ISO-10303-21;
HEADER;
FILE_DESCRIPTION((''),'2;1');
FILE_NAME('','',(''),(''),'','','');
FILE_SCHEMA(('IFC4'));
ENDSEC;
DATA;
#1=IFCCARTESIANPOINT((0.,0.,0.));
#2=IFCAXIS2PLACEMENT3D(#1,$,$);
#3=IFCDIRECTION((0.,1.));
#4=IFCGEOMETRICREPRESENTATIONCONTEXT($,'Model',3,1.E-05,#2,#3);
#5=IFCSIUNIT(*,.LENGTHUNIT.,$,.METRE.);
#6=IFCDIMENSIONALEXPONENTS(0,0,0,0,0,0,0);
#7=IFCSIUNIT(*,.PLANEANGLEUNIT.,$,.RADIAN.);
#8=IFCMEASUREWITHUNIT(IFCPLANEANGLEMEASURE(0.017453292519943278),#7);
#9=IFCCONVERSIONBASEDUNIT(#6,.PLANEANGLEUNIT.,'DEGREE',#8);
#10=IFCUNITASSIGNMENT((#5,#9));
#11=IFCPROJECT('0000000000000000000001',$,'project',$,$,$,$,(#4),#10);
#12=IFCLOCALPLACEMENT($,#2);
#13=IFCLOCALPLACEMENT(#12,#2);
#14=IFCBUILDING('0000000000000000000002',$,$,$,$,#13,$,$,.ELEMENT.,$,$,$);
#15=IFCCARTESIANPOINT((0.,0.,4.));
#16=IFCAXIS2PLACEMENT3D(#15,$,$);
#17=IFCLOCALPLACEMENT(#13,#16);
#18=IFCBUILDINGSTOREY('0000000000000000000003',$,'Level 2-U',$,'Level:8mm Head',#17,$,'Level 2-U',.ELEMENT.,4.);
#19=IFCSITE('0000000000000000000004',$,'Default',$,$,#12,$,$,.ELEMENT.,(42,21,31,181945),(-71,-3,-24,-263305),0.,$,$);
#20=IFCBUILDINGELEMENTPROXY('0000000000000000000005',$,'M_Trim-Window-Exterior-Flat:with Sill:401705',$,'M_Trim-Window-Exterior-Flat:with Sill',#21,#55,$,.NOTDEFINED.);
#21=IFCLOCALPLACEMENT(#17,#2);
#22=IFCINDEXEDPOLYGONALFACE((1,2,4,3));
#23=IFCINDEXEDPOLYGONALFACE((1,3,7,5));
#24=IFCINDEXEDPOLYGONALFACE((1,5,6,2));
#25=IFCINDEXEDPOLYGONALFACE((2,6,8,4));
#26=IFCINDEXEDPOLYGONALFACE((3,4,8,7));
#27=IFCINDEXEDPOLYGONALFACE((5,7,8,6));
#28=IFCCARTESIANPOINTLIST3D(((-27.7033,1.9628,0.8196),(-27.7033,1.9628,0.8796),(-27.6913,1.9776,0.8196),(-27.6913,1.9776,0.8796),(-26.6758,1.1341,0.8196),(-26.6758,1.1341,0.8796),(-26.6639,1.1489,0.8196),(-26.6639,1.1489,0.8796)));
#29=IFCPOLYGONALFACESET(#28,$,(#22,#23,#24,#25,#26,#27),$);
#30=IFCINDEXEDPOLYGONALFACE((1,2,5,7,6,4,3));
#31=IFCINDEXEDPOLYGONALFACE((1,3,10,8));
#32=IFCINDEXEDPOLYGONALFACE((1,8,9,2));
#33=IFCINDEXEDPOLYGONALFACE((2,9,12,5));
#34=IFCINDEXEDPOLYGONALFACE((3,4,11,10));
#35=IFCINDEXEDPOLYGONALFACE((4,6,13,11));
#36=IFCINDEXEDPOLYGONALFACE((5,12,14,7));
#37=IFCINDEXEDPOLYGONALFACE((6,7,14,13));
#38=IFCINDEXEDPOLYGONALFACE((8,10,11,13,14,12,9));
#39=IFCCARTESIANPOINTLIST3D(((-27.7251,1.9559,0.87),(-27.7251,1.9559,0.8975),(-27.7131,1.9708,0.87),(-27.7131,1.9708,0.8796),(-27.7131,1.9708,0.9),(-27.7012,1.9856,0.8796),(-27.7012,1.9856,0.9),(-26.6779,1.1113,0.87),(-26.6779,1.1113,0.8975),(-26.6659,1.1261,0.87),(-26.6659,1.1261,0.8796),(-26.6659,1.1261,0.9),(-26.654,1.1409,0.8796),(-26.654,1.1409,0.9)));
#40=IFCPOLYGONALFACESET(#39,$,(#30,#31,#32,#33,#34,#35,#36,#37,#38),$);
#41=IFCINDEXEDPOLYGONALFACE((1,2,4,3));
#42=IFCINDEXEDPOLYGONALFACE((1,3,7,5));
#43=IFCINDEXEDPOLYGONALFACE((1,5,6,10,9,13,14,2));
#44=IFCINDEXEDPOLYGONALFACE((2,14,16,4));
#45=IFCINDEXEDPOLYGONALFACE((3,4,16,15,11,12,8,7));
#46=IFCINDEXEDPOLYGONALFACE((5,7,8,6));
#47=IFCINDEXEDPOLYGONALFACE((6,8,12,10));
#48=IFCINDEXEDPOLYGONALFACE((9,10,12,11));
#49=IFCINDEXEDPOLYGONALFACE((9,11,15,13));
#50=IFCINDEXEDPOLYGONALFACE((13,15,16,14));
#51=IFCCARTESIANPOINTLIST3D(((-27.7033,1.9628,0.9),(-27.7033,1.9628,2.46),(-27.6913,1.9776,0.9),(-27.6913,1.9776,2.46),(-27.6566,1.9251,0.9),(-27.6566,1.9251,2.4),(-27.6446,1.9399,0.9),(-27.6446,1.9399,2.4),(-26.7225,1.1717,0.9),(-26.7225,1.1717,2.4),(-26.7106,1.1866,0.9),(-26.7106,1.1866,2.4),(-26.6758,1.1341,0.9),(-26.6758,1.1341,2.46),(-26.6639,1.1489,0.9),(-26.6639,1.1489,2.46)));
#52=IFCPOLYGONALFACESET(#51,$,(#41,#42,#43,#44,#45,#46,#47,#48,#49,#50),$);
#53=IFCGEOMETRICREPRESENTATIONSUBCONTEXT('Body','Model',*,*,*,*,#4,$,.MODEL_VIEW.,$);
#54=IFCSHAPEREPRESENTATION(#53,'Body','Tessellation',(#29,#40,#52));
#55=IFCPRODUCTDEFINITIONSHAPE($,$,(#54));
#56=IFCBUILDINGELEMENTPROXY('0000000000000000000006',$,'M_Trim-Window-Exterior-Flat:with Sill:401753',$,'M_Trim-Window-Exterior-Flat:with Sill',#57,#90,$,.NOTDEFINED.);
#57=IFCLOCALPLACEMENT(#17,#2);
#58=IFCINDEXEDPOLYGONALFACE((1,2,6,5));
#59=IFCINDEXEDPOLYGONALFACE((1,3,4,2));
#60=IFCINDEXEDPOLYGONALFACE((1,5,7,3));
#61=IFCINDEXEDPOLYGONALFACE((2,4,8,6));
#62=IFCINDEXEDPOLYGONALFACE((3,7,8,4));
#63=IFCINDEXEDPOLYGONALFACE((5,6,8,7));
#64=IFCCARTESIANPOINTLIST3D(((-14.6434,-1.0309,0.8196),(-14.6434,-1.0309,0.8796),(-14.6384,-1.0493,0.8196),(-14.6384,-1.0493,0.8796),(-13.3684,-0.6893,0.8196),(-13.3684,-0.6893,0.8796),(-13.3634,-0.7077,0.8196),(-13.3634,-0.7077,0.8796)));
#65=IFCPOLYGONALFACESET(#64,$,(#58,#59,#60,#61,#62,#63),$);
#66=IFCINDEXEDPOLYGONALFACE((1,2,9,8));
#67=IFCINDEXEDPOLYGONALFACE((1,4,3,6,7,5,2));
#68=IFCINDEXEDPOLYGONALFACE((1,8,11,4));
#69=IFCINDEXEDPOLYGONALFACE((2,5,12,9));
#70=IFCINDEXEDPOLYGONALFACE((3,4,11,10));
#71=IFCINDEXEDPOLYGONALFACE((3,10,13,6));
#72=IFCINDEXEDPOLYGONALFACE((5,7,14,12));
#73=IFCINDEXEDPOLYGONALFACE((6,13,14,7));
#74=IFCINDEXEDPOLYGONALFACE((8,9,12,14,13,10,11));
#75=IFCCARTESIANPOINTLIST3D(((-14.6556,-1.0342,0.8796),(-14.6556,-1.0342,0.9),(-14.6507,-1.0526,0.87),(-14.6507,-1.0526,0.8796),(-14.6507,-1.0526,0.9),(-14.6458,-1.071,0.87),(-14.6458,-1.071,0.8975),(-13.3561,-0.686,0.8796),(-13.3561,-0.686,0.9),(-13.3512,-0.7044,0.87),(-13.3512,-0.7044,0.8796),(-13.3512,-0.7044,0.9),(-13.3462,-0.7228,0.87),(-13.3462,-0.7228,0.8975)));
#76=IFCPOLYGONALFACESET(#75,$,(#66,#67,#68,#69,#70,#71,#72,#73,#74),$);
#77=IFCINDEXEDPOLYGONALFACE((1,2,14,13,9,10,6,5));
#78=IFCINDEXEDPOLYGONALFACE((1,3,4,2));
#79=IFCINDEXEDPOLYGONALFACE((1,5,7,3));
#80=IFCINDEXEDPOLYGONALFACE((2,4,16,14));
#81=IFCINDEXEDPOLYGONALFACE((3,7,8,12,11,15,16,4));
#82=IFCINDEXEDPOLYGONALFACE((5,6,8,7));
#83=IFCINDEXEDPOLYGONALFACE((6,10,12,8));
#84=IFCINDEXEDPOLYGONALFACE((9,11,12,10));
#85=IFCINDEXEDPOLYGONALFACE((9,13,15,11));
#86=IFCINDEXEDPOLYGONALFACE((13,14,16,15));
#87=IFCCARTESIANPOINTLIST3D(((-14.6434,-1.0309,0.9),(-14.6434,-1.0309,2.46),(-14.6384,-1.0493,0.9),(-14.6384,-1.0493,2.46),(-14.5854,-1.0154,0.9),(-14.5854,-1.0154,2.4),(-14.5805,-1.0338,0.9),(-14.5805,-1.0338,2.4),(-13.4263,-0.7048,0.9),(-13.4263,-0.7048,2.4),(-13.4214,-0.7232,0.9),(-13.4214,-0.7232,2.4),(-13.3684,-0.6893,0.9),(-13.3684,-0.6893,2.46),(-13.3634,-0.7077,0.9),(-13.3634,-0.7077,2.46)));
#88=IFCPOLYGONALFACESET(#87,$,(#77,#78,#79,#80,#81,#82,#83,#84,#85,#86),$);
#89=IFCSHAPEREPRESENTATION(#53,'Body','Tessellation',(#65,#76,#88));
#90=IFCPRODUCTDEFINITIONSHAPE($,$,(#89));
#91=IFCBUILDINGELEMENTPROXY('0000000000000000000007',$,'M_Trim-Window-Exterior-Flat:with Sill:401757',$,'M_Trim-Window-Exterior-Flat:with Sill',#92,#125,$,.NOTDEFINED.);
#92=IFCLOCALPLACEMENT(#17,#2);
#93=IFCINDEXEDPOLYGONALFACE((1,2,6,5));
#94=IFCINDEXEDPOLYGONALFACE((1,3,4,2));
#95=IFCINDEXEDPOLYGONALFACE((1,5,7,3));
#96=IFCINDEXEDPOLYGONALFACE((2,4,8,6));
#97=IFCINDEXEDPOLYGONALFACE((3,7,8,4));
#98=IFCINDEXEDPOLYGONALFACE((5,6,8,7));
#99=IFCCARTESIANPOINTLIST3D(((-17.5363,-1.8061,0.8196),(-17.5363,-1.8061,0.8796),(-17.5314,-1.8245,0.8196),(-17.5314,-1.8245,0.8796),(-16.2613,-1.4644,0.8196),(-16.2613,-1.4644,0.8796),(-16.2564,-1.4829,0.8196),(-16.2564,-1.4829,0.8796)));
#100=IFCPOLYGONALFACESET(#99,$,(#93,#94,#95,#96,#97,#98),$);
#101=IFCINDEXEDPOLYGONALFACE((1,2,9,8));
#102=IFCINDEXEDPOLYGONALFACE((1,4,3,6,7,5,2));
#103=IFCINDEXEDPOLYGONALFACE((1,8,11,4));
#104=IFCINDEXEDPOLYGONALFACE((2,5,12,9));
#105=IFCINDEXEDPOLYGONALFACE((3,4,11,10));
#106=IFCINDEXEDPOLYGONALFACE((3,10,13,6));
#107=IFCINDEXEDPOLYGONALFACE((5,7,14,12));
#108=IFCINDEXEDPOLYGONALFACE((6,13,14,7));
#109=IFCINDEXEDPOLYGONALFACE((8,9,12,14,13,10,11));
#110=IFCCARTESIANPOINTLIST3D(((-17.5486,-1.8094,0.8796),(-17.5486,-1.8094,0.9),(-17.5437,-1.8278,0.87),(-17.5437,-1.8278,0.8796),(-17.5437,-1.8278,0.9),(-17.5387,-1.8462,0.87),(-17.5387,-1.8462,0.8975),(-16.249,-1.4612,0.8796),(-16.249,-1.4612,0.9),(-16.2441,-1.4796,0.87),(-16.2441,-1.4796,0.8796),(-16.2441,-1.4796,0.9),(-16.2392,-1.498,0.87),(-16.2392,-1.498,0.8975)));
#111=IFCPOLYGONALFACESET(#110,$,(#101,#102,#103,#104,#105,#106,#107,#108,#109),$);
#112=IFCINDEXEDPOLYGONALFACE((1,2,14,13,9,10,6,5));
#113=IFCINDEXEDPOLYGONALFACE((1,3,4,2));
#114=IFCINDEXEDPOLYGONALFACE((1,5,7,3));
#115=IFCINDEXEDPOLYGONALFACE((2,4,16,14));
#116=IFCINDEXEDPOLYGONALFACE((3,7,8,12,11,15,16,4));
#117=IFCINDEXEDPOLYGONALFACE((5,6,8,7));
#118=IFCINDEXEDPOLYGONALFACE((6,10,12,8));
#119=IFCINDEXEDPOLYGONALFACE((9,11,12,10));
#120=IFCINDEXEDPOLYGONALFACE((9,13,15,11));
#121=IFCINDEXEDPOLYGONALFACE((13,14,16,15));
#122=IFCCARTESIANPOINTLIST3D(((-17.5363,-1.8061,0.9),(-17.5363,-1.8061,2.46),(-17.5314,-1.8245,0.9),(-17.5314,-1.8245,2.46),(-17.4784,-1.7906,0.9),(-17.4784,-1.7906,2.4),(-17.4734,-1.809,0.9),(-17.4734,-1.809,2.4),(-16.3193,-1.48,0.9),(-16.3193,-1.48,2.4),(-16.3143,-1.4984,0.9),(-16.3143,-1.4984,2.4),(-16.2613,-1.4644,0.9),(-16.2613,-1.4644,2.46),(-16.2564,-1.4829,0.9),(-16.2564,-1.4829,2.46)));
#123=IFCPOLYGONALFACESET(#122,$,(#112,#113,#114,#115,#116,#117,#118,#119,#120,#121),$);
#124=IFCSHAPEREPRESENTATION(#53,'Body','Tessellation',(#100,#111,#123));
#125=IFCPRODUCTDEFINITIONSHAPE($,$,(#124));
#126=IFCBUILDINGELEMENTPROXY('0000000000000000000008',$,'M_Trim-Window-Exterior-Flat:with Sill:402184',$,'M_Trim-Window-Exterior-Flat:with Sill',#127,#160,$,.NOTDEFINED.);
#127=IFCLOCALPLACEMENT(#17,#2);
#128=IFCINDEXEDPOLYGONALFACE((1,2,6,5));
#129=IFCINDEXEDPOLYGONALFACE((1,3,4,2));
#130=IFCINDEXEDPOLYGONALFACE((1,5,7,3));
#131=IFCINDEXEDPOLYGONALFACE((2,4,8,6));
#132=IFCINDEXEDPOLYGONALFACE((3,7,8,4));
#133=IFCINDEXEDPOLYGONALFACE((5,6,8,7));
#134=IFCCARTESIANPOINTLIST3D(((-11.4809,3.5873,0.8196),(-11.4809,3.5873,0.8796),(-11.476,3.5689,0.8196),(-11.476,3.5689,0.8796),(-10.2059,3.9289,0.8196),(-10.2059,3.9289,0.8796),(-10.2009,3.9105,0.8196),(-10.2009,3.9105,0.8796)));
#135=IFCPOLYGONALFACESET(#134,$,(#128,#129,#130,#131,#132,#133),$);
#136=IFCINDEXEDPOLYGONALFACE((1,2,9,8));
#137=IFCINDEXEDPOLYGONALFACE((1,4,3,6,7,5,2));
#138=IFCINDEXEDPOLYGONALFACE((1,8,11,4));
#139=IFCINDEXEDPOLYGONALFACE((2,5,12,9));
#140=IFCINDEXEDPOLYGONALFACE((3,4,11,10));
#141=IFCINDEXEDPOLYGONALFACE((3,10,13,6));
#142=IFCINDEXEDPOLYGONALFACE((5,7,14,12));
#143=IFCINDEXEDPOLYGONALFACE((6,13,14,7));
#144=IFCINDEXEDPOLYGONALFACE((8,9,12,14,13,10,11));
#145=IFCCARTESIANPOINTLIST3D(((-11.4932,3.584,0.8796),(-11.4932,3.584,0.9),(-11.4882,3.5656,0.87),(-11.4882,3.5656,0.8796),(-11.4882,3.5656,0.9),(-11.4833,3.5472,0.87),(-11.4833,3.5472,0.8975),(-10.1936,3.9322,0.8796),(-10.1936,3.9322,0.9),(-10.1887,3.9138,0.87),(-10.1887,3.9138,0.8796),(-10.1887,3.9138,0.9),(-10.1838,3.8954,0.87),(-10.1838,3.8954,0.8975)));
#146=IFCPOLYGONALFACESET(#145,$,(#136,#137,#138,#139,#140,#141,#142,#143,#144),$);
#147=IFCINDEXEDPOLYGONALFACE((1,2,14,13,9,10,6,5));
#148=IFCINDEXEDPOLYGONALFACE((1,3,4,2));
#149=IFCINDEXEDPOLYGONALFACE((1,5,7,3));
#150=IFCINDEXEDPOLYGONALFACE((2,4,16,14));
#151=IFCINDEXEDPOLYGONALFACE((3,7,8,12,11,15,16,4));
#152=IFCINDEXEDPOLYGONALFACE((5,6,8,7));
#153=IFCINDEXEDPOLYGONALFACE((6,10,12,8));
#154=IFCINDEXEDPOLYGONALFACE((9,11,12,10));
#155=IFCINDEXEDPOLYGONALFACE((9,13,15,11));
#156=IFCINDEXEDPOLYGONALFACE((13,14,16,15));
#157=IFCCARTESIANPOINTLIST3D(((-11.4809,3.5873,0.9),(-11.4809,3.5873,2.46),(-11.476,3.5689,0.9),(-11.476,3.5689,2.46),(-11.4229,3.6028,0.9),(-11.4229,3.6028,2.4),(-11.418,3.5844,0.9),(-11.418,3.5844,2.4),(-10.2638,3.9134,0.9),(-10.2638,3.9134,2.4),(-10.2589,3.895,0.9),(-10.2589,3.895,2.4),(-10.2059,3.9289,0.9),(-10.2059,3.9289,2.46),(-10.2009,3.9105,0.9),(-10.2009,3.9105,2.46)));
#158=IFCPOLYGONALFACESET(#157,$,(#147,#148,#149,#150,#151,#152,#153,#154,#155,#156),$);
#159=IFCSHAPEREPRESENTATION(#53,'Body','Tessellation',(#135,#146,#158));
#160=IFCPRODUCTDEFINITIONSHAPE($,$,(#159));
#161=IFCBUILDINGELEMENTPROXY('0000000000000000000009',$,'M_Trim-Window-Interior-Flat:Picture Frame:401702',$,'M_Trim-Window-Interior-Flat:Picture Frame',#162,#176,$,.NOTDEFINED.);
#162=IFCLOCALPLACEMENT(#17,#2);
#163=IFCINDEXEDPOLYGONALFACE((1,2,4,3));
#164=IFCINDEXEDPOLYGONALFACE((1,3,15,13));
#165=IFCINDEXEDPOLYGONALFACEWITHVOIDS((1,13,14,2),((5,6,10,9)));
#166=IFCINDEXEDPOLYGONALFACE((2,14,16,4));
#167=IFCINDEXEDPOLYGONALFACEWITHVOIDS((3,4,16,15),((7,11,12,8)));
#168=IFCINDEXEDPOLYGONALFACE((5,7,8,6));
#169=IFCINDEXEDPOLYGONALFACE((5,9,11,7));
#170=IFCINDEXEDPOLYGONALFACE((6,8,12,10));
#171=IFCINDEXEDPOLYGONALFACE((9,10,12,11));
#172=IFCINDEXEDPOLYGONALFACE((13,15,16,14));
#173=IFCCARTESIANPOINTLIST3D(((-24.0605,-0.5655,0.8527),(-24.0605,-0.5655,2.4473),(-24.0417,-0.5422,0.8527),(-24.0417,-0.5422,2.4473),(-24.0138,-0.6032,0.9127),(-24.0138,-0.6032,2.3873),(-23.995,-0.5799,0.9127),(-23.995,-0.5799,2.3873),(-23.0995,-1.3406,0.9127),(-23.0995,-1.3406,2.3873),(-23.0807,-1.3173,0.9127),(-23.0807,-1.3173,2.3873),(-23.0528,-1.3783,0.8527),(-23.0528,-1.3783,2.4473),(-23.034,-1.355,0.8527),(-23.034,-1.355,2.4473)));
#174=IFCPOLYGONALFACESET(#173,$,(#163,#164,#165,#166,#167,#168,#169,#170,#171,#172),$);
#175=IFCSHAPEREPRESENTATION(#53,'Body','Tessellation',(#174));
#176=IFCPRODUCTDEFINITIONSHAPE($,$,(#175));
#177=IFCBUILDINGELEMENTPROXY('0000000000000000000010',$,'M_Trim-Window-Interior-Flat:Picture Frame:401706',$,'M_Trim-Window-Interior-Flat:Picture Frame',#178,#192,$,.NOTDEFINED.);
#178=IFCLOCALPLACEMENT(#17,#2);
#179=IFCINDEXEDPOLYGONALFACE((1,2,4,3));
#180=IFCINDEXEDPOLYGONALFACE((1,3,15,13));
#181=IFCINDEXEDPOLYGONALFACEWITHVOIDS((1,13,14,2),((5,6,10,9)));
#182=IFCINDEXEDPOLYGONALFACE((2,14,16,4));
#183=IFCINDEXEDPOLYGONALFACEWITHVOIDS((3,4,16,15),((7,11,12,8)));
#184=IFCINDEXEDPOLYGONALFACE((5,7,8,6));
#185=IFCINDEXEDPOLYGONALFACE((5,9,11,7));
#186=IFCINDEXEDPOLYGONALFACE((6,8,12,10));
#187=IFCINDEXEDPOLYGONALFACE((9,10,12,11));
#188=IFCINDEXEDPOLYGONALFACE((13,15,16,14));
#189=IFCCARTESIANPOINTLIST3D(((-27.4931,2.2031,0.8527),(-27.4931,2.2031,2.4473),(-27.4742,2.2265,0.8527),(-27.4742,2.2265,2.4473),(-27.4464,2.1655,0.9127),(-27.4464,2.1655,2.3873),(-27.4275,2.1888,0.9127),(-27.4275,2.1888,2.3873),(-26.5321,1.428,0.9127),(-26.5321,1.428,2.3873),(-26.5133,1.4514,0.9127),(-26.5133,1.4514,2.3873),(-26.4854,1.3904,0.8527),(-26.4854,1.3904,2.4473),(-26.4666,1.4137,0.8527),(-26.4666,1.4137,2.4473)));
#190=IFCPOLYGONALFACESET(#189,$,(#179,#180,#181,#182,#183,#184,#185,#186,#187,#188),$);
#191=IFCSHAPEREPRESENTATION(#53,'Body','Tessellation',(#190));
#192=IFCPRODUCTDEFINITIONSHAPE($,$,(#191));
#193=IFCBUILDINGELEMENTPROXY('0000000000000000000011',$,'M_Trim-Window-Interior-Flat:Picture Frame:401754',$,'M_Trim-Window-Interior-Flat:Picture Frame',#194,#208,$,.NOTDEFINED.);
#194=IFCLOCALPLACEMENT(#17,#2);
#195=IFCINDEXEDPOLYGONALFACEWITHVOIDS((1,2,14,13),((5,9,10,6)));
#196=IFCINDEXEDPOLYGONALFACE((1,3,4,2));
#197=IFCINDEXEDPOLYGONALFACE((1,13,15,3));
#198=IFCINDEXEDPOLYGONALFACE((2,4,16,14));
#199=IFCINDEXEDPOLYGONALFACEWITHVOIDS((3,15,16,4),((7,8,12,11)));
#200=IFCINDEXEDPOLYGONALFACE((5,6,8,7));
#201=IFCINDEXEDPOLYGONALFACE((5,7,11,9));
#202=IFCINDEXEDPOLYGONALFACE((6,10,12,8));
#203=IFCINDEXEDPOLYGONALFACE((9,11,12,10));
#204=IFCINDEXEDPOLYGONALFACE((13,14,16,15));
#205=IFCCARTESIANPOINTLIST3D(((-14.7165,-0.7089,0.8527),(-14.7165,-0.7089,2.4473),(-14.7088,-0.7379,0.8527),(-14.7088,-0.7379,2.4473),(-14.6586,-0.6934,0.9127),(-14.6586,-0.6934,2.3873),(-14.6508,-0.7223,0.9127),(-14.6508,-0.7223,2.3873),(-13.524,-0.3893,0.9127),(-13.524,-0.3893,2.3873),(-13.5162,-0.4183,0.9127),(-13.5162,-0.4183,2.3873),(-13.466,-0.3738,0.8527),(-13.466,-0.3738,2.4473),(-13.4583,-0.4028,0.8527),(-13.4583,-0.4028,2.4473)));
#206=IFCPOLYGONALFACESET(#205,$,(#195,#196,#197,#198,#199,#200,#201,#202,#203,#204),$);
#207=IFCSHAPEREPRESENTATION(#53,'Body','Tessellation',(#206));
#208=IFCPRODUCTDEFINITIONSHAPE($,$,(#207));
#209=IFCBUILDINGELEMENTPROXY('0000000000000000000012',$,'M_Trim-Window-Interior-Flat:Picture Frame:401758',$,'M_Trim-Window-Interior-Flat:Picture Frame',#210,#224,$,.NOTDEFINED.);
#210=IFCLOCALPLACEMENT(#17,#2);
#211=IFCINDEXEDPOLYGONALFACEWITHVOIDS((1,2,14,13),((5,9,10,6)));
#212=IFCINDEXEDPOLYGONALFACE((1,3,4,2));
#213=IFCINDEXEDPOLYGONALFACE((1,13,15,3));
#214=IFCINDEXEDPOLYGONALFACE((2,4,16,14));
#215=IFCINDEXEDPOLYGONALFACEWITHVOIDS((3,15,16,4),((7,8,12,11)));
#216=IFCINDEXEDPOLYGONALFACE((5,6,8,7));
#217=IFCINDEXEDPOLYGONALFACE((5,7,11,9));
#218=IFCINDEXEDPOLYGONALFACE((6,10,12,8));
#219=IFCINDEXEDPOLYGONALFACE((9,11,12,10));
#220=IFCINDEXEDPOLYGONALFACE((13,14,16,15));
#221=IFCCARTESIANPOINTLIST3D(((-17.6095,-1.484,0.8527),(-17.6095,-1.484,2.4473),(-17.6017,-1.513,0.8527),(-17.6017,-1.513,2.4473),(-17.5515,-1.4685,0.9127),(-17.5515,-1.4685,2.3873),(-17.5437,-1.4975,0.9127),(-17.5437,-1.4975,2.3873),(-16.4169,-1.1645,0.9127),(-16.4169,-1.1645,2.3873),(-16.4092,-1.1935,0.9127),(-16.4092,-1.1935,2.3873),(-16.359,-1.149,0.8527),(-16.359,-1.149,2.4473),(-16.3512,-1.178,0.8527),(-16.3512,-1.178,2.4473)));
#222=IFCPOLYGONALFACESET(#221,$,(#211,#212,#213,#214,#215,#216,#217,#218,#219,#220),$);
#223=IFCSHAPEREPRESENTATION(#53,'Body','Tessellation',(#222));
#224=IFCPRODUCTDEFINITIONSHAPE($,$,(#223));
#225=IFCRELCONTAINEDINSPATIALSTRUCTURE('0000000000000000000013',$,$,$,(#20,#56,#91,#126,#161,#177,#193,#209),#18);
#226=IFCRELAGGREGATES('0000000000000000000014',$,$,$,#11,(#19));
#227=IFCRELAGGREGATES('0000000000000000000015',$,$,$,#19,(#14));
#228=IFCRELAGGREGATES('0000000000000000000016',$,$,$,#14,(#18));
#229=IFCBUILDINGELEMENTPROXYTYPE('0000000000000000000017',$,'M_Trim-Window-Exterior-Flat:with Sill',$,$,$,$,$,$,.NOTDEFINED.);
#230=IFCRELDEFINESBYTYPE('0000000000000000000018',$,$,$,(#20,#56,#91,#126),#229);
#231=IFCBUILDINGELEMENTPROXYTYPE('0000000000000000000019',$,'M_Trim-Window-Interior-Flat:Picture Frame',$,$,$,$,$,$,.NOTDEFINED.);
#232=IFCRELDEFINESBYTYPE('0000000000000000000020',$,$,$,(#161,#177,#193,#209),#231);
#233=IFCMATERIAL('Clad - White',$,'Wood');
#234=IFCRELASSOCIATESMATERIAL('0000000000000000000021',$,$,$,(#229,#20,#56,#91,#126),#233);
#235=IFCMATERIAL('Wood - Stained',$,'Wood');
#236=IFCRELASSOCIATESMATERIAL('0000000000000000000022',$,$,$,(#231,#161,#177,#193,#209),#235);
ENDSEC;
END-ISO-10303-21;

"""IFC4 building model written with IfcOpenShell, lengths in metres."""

from ifc_helpers import new_model, entity, si_unit, converted_unit, direction, frame, frame_2d, origin, place, context, subcontext, project, spatial, polyline, rectangle, outline, extrude, source, transform, mapped, material, type_object, type_shapes, element, save


model = new_model("IFC4")

# Units and contexts
model_context = context("Model", 3, precision=1e-05, world=origin(), true_north=direction((0.0, 1.0)))
body_context = subcontext(model_context, "Body", "Model", "MODEL_VIEW")
ifc_project = project(units=[si_unit("LENGTHUNIT", "METRE"), converted_unit("PLANEANGLEUNIT", "DEGREE", entity("IfcPlaneAngleMeasure", 0.017453292519943278), si_unit("PLANEANGLEUNIT", "RADIAN"), dimensions=[0, 0, 0, 0, 0, 0, 0])], contexts=[model_context])

# Site, building, storey
site_placement = place(None, origin())
site = spatial("IfcSite", under=ifc_project, at=site_placement, Name="Default", CompositionType="ELEMENT", RefLatitude=(42, 21, 31, 181945), RefLongitude=(-71, -3, -24, -263305), RefElevation=0.0)
building_placement = place(site_placement, origin())
building = spatial("IfcBuilding", under=site, at=building_placement, CompositionType="ELEMENT")
storey_placement = place(building_placement, frame((0.0, 0.0, 4.0)))
storey = spatial("IfcBuildingStorey", under=building, at=storey_placement, Name="Level 2-U", ObjectType="Level:8mm Head", LongName="Level 2-U", CompositionType="ELEMENT", Elevation=4.0)

# Building element proxies
ifc_material_1 = material(Name="Clad - White", Category="Wood")
ifc_material_2 = material(Name="Wood - Stained", Category="Wood")
building_element_proxy_type_1 = type_object("IfcBuildingElementProxyType", Name="M_Trim-Window-Exterior-Flat:with Sill", PredefinedType="NOTDEFINED", material=ifc_material_1)
shared_shape_1 = source(origin(), body_context, "Body", "SweptSolid", [
    extrude(rectangle(XDim=1.32, YDim=0.06, at=frame_2d((0.0, 0.0), x_axis=(1.0, 0.0))), frame((0.0, -1.5504, 0.0), z_axis=(0.0, 0.0, 1.0), x_axis=(-1.0, 0.0, 0.0)), (0.0, 0.0, 1.0), 0.019),
    extrude(outline(polyline([(-0.019, -0.0152), (0.0, -0.0152), (0.0, -0.0057), (0.019, -0.0057), (0.019, 0.0148), (0.0, 0.0148), (-0.019, 0.0123), (-0.019, -0.0152)])), frame((-0.6727, -1.5148, 0.019), z_axis=(1.0, 0.0, 0.0), x_axis=(0.0, 0.0, -1.0)), (0.0, 0.0, 1.0), 1.3454),
    extrude(outline(polyline([(-0.795, -0.66), (0.765, -0.66), (0.765, -0.6), (-0.735, -0.6), (-0.735, 0.6), (0.765, 0.6), (0.765, 0.66), (-0.795, 0.66), (-0.795, -0.66)])), frame((0.0, -0.735, 0.0), z_axis=(0.0, 0.0, 1.0), x_axis=(0.0, -1.0, 0.0)), (0.0, 0.0, 1.0), 0.019),
])
type_shapes(building_element_proxy_type_1, [shared_shape_1])
for number, where, z_axis, x_axis, name in (
    (1, (-27.1776, 1.5632, 2.4), (-0.62782, -0.778359, 0.0), (0.778359, -0.62782, 0.0), "M_Trim-Window-Exterior-Flat:with Sill:401705"),
    (2, (-14.0059, -0.8601, 2.4), (0.258819, -0.965926, 0.0), (0.965926, 0.258819, 0.0), "M_Trim-Window-Exterior-Flat:with Sill:401753"),
    (3, (-16.8988, -1.6353, 2.4), (0.258819, -0.965926, 0.0), (0.965926, 0.258819, 0.0), "M_Trim-Window-Exterior-Flat:with Sill:401757"),
    (4, (-10.8434, 3.7581, 2.4), (0.258819, -0.965926, 0.0), (0.965926, 0.258819, 0.0), "M_Trim-Window-Exterior-Flat:with Sill:402184"),
):
    element("IfcBuildingElementProxy", number, at=place(storey_placement, frame(where, z_axis=z_axis, x_axis=x_axis)), inside=storey, type_object=building_element_proxy_type_1, material=ifc_material_1, Name=name, ObjectType="M_Trim-Window-Exterior-Flat:with Sill", PredefinedType="NOTDEFINED", context=body_context, shape_type="MappedRepresentation", body=[
        mapped(shared_shape_1, transform((0.0, 0.0, 0.0), scale=1.0)),
    ])
building_element_proxy_type_2 = type_object("IfcBuildingElementProxyType", Name="M_Trim-Window-Interior-Flat:Picture Frame", PredefinedType="NOTDEFINED", material=ifc_material_2)
shared_shape_2 = source(origin(), body_context, "Body", "SweptSolid", [
    extrude(outline(polyline([(-0.6473, -0.7973), (0.6473, -0.7973), (0.6473, 0.7973), (-0.6473, 0.7973), (-0.6473, -0.7973)]), holes=[polyline([(-0.5873, -0.7373), (-0.5873, 0.7373), (0.5873, 0.7373), (0.5873, -0.7373), (-0.5873, -0.7373)])]), frame((0.0, -0.75, 0.0), z_axis=(0.0, 0.0, 1.0), x_axis=(-1.0, 0.0, 0.0)), (0.0, 0.0, 1.0), 0.03),
])
type_shapes(building_element_proxy_type_2, [shared_shape_2])
for number, where, z_axis, x_axis, name in (
    (5, (-23.5567, -0.9719, 2.4), (0.62782, 0.778359, 0.0), (-0.778359, 0.62782, 0.0), "M_Trim-Window-Interior-Flat:Picture Frame:401702"),
    (6, (-26.9892, 1.7968, 2.4), (0.62782, 0.778359, 0.0), (-0.778359, 0.62782, 0.0), "M_Trim-Window-Interior-Flat:Picture Frame:401706"),
    (7, (-14.0835, -0.5703, 2.4), (-0.258819, 0.965926, 0.0), (-0.965926, -0.258819, 0.0), "M_Trim-Window-Interior-Flat:Picture Frame:401754"),
    (8, (-16.9765, -1.3455, 2.4), (-0.258819, 0.965926, 0.0), (-0.965926, -0.258819, 0.0), "M_Trim-Window-Interior-Flat:Picture Frame:401758"),
):
    element("IfcBuildingElementProxy", number, at=place(storey_placement, frame(where, z_axis=z_axis, x_axis=x_axis)), inside=storey, type_object=building_element_proxy_type_2, material=ifc_material_2, Name=name, ObjectType="M_Trim-Window-Interior-Flat:Picture Frame", PredefinedType="NOTDEFINED", context=body_context, shape_type="MappedRepresentation", body=[
        mapped(shared_shape_2, transform((0.0, 0.0, 0.0), scale=1.0)),
    ])

save(model, "model.ifc")
